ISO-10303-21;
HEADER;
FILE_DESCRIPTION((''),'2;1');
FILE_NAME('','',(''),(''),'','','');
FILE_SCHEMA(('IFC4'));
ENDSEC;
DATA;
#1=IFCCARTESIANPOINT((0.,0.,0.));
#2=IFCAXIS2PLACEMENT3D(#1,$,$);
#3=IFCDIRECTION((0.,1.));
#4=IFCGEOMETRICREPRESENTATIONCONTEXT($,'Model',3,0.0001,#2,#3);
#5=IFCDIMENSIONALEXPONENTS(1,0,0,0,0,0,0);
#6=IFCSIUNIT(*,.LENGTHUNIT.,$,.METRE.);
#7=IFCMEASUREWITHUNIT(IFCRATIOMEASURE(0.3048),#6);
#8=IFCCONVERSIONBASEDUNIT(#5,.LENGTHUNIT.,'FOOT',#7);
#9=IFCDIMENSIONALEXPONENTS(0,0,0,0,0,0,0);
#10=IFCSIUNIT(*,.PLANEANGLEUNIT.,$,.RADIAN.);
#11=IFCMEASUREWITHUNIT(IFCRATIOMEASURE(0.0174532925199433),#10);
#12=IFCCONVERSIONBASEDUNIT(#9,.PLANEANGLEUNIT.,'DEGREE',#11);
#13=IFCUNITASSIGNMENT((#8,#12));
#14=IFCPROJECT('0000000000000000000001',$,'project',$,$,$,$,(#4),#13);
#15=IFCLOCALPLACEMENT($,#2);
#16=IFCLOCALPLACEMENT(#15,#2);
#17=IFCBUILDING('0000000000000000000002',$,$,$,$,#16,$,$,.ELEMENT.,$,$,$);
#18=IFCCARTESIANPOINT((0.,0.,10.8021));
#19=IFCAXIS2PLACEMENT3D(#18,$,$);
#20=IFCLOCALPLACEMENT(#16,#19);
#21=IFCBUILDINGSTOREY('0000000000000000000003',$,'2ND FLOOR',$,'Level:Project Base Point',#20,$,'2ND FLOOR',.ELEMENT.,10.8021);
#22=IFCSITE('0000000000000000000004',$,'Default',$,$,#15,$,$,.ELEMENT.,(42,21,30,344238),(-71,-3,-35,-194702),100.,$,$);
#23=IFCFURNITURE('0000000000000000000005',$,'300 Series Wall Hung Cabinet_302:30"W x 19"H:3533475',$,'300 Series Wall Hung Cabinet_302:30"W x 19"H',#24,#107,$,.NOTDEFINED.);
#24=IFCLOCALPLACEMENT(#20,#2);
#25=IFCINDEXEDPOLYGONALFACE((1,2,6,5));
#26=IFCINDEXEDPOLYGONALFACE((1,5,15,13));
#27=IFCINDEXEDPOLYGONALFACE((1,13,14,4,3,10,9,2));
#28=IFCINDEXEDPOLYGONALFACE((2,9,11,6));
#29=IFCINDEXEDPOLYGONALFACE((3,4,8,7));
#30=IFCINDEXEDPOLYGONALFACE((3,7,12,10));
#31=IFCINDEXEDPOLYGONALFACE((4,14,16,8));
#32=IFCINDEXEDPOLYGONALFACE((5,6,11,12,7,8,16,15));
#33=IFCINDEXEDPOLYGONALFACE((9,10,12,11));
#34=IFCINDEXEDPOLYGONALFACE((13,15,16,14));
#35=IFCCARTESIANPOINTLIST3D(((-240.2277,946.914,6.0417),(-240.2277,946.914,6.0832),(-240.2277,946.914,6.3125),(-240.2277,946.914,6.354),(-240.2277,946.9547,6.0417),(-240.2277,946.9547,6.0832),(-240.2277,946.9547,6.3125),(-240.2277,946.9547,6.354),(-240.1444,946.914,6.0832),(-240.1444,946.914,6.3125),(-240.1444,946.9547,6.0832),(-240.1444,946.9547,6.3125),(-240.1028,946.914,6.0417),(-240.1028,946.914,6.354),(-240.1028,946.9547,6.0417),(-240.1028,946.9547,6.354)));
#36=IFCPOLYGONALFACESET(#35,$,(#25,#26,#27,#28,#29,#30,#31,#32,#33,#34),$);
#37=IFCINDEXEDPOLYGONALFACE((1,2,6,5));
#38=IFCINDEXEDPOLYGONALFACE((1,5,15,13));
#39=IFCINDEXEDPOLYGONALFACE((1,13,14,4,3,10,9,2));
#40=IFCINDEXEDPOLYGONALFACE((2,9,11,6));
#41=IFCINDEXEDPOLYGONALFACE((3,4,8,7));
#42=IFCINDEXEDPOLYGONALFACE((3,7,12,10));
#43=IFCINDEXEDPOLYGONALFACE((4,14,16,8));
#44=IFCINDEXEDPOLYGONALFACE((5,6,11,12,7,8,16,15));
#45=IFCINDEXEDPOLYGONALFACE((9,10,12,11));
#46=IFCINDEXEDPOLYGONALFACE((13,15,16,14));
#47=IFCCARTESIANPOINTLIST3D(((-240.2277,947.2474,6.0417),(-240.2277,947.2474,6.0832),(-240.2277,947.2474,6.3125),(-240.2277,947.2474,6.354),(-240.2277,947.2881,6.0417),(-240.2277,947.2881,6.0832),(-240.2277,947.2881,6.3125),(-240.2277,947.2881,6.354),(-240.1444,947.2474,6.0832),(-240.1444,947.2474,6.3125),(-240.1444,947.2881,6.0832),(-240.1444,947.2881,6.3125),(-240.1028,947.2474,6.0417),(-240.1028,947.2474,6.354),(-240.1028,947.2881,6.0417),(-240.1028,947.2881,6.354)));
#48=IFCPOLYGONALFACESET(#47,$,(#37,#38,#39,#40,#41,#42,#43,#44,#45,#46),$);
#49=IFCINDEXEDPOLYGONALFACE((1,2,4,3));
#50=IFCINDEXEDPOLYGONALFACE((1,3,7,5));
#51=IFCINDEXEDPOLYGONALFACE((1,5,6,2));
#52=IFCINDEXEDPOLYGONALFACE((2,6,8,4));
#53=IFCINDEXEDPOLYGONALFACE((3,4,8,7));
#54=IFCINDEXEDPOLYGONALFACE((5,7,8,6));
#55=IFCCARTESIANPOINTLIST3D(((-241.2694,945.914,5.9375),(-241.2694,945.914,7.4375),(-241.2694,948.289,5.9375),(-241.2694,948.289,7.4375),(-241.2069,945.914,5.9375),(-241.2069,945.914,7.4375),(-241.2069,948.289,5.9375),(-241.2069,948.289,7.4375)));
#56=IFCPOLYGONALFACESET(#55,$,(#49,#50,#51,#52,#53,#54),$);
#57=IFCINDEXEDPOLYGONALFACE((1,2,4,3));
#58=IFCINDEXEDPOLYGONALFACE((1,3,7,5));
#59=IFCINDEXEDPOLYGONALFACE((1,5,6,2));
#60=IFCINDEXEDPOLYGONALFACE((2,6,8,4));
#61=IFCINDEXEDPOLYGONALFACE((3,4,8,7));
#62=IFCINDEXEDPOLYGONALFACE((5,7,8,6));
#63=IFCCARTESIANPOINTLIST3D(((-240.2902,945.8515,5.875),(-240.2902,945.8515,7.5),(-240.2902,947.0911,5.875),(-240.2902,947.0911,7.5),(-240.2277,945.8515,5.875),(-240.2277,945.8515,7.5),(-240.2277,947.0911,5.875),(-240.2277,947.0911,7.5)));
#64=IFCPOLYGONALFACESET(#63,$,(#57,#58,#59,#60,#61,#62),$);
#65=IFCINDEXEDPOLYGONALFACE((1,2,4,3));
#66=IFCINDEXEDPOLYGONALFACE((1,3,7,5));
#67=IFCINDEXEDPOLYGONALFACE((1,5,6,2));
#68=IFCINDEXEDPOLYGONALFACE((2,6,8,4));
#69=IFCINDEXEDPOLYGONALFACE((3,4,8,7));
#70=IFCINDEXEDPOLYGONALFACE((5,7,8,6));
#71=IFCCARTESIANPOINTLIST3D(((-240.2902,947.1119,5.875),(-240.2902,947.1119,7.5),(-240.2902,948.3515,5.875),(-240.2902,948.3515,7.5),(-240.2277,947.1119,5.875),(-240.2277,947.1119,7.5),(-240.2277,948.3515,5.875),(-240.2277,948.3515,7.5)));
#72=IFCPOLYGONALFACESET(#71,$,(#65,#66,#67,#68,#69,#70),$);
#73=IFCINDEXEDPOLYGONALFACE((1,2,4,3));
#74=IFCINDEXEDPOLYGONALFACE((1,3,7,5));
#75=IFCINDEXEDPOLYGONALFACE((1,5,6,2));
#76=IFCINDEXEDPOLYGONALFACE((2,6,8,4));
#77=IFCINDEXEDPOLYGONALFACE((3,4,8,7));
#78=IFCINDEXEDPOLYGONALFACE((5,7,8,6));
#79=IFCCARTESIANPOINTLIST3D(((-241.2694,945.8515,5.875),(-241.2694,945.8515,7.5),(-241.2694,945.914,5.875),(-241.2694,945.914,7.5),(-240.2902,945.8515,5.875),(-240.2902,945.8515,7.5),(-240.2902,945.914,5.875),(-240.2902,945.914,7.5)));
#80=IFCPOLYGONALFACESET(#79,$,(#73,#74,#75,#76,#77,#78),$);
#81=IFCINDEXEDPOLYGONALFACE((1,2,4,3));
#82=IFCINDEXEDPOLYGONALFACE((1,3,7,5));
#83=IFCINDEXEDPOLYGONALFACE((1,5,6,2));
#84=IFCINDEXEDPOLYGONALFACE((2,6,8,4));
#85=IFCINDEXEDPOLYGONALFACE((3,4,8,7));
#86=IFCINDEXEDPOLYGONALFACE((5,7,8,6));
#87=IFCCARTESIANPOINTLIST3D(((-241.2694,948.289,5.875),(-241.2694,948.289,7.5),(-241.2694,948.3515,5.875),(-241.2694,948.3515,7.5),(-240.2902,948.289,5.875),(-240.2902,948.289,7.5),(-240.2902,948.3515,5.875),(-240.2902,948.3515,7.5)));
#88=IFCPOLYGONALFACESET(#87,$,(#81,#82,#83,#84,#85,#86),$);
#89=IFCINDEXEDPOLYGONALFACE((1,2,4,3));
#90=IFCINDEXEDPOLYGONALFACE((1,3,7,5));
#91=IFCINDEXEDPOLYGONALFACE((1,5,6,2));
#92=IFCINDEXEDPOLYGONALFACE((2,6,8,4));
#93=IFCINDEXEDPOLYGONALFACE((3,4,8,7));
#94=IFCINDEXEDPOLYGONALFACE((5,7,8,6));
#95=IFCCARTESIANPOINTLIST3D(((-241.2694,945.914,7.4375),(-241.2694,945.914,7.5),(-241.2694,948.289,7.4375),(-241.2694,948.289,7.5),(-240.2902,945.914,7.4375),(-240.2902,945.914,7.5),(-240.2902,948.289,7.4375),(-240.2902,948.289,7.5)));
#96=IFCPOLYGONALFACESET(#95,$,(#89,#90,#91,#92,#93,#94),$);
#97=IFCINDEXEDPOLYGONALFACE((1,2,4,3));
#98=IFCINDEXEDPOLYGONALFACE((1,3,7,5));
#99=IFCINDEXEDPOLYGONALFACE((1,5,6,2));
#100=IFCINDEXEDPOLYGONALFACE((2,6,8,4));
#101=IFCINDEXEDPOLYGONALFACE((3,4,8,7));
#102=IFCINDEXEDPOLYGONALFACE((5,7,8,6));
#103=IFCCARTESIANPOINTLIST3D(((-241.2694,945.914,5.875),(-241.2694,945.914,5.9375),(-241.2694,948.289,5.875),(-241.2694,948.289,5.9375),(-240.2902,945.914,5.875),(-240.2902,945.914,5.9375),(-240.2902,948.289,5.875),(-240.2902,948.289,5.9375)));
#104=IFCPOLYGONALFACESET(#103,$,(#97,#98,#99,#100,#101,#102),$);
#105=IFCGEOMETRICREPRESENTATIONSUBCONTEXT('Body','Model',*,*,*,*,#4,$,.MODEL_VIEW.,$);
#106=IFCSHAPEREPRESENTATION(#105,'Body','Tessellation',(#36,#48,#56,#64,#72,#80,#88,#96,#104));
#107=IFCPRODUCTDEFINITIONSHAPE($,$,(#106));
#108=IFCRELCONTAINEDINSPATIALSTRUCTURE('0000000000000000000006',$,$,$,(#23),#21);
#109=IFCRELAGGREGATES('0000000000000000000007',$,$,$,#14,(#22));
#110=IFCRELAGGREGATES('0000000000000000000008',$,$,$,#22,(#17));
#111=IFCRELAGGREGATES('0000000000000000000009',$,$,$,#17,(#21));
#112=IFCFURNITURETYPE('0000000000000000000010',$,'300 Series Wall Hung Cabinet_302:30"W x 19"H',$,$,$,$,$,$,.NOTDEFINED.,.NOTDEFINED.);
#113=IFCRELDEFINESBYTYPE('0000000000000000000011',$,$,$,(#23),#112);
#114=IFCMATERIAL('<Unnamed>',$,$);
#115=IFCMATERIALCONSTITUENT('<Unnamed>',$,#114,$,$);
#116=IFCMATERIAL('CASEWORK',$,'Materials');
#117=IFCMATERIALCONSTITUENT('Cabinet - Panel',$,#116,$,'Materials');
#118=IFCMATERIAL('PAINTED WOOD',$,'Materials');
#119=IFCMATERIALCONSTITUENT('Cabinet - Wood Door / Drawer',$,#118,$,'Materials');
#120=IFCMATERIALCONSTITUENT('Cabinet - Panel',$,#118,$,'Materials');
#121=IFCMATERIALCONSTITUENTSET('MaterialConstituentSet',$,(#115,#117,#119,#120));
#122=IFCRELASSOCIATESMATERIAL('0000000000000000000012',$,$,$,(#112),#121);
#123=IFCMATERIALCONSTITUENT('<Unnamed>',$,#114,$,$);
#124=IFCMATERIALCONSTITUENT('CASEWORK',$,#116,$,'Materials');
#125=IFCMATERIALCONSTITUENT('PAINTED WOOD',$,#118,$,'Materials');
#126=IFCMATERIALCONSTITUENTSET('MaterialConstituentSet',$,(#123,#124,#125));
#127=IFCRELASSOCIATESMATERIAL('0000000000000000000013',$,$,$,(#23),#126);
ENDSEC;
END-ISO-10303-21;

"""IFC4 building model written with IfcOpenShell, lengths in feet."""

from ifc_helpers import new_model, entity, si_unit, converted_unit, direction, frame, frame_2d, origin, origin_2d_with_axis, place, context, subcontext, project, spatial, polyline, rectangle, outline, extrude, source, transform, mapped, material, constituent, constituent_set, type_object, type_shapes, element, save


model = new_model("IFC4")

# Units and contexts
model_context = context("Model", 3, precision=0.0001, world=origin(), true_north=direction((0.0, 1.0)))
body_context = subcontext(model_context, "Body", "Model", "MODEL_VIEW")
ifc_project = project(units=[converted_unit("LENGTHUNIT", "FOOT", entity("IfcRatioMeasure", 0.3048), si_unit("LENGTHUNIT", "METRE"), dimensions=[1, 0, 0, 0, 0, 0, 0]), converted_unit("PLANEANGLEUNIT", "DEGREE", entity("IfcRatioMeasure", 0.0174532925199433), si_unit("PLANEANGLEUNIT", "RADIAN"), dimensions=[0, 0, 0, 0, 0, 0, 0])], contexts=[model_context])

# Site, building, storey
site_placement = place(None, origin())
site = spatial("IfcSite", under=ifc_project, at=site_placement, Name="Default", CompositionType="ELEMENT", RefLatitude=(42, 21, 30, 344238), RefLongitude=(-71, -3, -35, -194702), RefElevation=100.0)
building_placement = place(site_placement, origin())
building = spatial("IfcBuilding", under=site, at=building_placement, CompositionType="ELEMENT")
storey_placement = place(building_placement, frame((0.0, 0.0, 10.8021)))
storey = spatial("IfcBuildingStorey", under=building, at=storey_placement, Name="2ND FLOOR", ObjectType="Level:Project Base Point", LongName="2ND FLOOR", CompositionType="ELEMENT", Elevation=10.8021)

# Shared definitions
ifc_material_1 = material(Name="PAINTED WOOD", Category="Materials")
ifc_material_2 = material(Name="CASEWORK", Category="Materials")

# Furniture
ifc_material_3 = material(Name="<Unnamed>")
ifc_constituent_1 = constituent(ifc_material_3, Name="<Unnamed>")
ifc_constituent_2 = constituent(ifc_material_2, Name="CASEWORK", Category="Materials")
ifc_constituent_3 = constituent(ifc_material_1, Name="PAINTED WOOD", Category="Materials")
ifc_constituent_set_1 = constituent_set(constituents=[ifc_constituent_1, ifc_constituent_2, ifc_constituent_3], Name="MaterialConstituentSet")
ifc_constituent_4 = constituent(ifc_material_3, Name="<Unnamed>")
ifc_constituent_5 = constituent(ifc_material_2, Name="Cabinet - Panel", Category="Materials")
ifc_constituent_6 = constituent(ifc_material_1, Name="Cabinet - Wood Door / Drawer", Category="Materials")
ifc_constituent_7 = constituent(ifc_material_1, Name="Cabinet - Panel", Category="Materials")
ifc_constituent_set_2 = constituent_set(constituents=[ifc_constituent_4, ifc_constituent_5, ifc_constituent_6, ifc_constituent_7], Name="MaterialConstituentSet")
furniture_type_1 = type_object("IfcFurnitureType", Name="300 Series Wall Hung Cabinet_302:30\"W x 19\"H", AssemblyPlace="NOTDEFINED", PredefinedType="NOTDEFINED", material=ifc_constituent_set_2)
shared_shape_1 = source(origin(), body_context, "Body", "SweptSolid", [
    extrude(outline(polyline([(0.1146, -0.0521), (0.1562, -0.0521), (0.1562, 0.0729), (-0.1562, 0.0729), (-0.1562, -0.0521), (-0.1146, -0.0521), (-0.1146, 0.0313), (0.1146, 0.0313), (0.1146, -0.0521)])), frame((1.0625, 0.0729, 0.3229), z_axis=(1.0, 0.0, 0.0), x_axis=(0.0, 0.0, 1.0)), (0.0, 0.0, 1.0), 0.0407),
    extrude(outline(polyline([(0.1146, -0.0521), (0.1562, -0.0521), (0.1562, 0.0729), (-0.1562, 0.0729), (-0.1562, -0.0521), (-0.1146, -0.0521), (-0.1146, 0.0313), (0.1146, 0.0313), (0.1146, -0.0521)])), frame((1.3958, 0.0729, 0.3229), z_axis=(1.0, 0.0, 0.0), x_axis=(0.0, 0.0, 1.0)), (0.0, 0.0, 1.0), 0.0407),
    extrude(rectangle(XDim=2.375, YDim=0.0625, at=origin_2d_with_axis()), frame((1.25, 1.1354, 0.0625), z_axis=(0.0, 0.0, 1.0), x_axis=(-1.0, 0.0, 0.0)), (0.0, 0.0, 1.0), 1.5),
    extrude(rectangle(XDim=1.2396, YDim=0.0625, at=origin_2d_with_axis()), frame((0.6198, 0.1562, 0.0), z_axis=(0.0, 0.0, 1.0), x_axis=(-1.0, 0.0, 0.0)), (0.0, 0.0, 1.0), 1.625),
    extrude(rectangle(XDim=1.2396, YDim=0.0625, at=frame_2d((0.0, 0.0), x_axis=(1.0, 0.0))), frame((1.8802, 0.1562, 0.0), z_axis=(0.0, 0.0, 1.0), x_axis=(-1.0, 0.0, 0.0)), (0.0, 0.0, 1.0), 1.625),
    extrude(rectangle(XDim=0.9792, YDim=0.0625, at=frame_2d((0.0, 0.0), x_axis=(1.0, 0.0))), frame((0.0313, 0.677, 0.0), z_axis=(0.0, 0.0, 1.0), x_axis=(0.0, -1.0, 0.0)), (0.0, 0.0, 1.0), 1.625),
    extrude(rectangle(XDim=0.9792, YDim=0.0625, at=frame_2d((0.0, 0.0), x_axis=(1.0, 0.0))), frame((2.4688, 0.677, 0.0), z_axis=(0.0, 0.0, 1.0), x_axis=(0.0, -1.0, 0.0)), (0.0, 0.0, 1.0), 1.625),
    extrude(rectangle(XDim=0.9792, YDim=2.375, at=frame_2d((0.0, 0.0), x_axis=(1.0, 0.0))), frame((1.25, 0.677, 1.5625), z_axis=(0.0, 0.0, 1.0), x_axis=(0.0, 1.0, 0.0)), (0.0, 0.0, 1.0), 0.0625),
    extrude(rectangle(XDim=0.9792, YDim=2.375, at=frame_2d((0.0, 0.0), x_axis=(1.0, 0.0))), frame((1.25, 0.677, 0.0), z_axis=(0.0, 0.0, 1.0), x_axis=(0.0, 1.0, 0.0)), (0.0, 0.0, 1.0), 0.0625),
])
type_shapes(furniture_type_1, [shared_shape_1])
furniture_1_placement = place(storey_placement, frame((-240.1028, 945.8515, 5.875), z_axis=(0.0, 0.0, 1.0), x_axis=(0.0, 1.0, 0.0)))
element("IfcFurniture", 1, at=furniture_1_placement, inside=storey, type_object=furniture_type_1, material=ifc_constituent_set_1, Name="300 Series Wall Hung Cabinet_302:30\"W x 19\"H:3533475", ObjectType="300 Series Wall Hung Cabinet_302:30\"W x 19\"H", PredefinedType="NOTDEFINED", context=body_context, shape_type="MappedRepresentation", body=[
    mapped(shared_shape_1, transform((0.0, 0.0, 0.0), scale=1.0)),
])

save(model, "model.ifc")
